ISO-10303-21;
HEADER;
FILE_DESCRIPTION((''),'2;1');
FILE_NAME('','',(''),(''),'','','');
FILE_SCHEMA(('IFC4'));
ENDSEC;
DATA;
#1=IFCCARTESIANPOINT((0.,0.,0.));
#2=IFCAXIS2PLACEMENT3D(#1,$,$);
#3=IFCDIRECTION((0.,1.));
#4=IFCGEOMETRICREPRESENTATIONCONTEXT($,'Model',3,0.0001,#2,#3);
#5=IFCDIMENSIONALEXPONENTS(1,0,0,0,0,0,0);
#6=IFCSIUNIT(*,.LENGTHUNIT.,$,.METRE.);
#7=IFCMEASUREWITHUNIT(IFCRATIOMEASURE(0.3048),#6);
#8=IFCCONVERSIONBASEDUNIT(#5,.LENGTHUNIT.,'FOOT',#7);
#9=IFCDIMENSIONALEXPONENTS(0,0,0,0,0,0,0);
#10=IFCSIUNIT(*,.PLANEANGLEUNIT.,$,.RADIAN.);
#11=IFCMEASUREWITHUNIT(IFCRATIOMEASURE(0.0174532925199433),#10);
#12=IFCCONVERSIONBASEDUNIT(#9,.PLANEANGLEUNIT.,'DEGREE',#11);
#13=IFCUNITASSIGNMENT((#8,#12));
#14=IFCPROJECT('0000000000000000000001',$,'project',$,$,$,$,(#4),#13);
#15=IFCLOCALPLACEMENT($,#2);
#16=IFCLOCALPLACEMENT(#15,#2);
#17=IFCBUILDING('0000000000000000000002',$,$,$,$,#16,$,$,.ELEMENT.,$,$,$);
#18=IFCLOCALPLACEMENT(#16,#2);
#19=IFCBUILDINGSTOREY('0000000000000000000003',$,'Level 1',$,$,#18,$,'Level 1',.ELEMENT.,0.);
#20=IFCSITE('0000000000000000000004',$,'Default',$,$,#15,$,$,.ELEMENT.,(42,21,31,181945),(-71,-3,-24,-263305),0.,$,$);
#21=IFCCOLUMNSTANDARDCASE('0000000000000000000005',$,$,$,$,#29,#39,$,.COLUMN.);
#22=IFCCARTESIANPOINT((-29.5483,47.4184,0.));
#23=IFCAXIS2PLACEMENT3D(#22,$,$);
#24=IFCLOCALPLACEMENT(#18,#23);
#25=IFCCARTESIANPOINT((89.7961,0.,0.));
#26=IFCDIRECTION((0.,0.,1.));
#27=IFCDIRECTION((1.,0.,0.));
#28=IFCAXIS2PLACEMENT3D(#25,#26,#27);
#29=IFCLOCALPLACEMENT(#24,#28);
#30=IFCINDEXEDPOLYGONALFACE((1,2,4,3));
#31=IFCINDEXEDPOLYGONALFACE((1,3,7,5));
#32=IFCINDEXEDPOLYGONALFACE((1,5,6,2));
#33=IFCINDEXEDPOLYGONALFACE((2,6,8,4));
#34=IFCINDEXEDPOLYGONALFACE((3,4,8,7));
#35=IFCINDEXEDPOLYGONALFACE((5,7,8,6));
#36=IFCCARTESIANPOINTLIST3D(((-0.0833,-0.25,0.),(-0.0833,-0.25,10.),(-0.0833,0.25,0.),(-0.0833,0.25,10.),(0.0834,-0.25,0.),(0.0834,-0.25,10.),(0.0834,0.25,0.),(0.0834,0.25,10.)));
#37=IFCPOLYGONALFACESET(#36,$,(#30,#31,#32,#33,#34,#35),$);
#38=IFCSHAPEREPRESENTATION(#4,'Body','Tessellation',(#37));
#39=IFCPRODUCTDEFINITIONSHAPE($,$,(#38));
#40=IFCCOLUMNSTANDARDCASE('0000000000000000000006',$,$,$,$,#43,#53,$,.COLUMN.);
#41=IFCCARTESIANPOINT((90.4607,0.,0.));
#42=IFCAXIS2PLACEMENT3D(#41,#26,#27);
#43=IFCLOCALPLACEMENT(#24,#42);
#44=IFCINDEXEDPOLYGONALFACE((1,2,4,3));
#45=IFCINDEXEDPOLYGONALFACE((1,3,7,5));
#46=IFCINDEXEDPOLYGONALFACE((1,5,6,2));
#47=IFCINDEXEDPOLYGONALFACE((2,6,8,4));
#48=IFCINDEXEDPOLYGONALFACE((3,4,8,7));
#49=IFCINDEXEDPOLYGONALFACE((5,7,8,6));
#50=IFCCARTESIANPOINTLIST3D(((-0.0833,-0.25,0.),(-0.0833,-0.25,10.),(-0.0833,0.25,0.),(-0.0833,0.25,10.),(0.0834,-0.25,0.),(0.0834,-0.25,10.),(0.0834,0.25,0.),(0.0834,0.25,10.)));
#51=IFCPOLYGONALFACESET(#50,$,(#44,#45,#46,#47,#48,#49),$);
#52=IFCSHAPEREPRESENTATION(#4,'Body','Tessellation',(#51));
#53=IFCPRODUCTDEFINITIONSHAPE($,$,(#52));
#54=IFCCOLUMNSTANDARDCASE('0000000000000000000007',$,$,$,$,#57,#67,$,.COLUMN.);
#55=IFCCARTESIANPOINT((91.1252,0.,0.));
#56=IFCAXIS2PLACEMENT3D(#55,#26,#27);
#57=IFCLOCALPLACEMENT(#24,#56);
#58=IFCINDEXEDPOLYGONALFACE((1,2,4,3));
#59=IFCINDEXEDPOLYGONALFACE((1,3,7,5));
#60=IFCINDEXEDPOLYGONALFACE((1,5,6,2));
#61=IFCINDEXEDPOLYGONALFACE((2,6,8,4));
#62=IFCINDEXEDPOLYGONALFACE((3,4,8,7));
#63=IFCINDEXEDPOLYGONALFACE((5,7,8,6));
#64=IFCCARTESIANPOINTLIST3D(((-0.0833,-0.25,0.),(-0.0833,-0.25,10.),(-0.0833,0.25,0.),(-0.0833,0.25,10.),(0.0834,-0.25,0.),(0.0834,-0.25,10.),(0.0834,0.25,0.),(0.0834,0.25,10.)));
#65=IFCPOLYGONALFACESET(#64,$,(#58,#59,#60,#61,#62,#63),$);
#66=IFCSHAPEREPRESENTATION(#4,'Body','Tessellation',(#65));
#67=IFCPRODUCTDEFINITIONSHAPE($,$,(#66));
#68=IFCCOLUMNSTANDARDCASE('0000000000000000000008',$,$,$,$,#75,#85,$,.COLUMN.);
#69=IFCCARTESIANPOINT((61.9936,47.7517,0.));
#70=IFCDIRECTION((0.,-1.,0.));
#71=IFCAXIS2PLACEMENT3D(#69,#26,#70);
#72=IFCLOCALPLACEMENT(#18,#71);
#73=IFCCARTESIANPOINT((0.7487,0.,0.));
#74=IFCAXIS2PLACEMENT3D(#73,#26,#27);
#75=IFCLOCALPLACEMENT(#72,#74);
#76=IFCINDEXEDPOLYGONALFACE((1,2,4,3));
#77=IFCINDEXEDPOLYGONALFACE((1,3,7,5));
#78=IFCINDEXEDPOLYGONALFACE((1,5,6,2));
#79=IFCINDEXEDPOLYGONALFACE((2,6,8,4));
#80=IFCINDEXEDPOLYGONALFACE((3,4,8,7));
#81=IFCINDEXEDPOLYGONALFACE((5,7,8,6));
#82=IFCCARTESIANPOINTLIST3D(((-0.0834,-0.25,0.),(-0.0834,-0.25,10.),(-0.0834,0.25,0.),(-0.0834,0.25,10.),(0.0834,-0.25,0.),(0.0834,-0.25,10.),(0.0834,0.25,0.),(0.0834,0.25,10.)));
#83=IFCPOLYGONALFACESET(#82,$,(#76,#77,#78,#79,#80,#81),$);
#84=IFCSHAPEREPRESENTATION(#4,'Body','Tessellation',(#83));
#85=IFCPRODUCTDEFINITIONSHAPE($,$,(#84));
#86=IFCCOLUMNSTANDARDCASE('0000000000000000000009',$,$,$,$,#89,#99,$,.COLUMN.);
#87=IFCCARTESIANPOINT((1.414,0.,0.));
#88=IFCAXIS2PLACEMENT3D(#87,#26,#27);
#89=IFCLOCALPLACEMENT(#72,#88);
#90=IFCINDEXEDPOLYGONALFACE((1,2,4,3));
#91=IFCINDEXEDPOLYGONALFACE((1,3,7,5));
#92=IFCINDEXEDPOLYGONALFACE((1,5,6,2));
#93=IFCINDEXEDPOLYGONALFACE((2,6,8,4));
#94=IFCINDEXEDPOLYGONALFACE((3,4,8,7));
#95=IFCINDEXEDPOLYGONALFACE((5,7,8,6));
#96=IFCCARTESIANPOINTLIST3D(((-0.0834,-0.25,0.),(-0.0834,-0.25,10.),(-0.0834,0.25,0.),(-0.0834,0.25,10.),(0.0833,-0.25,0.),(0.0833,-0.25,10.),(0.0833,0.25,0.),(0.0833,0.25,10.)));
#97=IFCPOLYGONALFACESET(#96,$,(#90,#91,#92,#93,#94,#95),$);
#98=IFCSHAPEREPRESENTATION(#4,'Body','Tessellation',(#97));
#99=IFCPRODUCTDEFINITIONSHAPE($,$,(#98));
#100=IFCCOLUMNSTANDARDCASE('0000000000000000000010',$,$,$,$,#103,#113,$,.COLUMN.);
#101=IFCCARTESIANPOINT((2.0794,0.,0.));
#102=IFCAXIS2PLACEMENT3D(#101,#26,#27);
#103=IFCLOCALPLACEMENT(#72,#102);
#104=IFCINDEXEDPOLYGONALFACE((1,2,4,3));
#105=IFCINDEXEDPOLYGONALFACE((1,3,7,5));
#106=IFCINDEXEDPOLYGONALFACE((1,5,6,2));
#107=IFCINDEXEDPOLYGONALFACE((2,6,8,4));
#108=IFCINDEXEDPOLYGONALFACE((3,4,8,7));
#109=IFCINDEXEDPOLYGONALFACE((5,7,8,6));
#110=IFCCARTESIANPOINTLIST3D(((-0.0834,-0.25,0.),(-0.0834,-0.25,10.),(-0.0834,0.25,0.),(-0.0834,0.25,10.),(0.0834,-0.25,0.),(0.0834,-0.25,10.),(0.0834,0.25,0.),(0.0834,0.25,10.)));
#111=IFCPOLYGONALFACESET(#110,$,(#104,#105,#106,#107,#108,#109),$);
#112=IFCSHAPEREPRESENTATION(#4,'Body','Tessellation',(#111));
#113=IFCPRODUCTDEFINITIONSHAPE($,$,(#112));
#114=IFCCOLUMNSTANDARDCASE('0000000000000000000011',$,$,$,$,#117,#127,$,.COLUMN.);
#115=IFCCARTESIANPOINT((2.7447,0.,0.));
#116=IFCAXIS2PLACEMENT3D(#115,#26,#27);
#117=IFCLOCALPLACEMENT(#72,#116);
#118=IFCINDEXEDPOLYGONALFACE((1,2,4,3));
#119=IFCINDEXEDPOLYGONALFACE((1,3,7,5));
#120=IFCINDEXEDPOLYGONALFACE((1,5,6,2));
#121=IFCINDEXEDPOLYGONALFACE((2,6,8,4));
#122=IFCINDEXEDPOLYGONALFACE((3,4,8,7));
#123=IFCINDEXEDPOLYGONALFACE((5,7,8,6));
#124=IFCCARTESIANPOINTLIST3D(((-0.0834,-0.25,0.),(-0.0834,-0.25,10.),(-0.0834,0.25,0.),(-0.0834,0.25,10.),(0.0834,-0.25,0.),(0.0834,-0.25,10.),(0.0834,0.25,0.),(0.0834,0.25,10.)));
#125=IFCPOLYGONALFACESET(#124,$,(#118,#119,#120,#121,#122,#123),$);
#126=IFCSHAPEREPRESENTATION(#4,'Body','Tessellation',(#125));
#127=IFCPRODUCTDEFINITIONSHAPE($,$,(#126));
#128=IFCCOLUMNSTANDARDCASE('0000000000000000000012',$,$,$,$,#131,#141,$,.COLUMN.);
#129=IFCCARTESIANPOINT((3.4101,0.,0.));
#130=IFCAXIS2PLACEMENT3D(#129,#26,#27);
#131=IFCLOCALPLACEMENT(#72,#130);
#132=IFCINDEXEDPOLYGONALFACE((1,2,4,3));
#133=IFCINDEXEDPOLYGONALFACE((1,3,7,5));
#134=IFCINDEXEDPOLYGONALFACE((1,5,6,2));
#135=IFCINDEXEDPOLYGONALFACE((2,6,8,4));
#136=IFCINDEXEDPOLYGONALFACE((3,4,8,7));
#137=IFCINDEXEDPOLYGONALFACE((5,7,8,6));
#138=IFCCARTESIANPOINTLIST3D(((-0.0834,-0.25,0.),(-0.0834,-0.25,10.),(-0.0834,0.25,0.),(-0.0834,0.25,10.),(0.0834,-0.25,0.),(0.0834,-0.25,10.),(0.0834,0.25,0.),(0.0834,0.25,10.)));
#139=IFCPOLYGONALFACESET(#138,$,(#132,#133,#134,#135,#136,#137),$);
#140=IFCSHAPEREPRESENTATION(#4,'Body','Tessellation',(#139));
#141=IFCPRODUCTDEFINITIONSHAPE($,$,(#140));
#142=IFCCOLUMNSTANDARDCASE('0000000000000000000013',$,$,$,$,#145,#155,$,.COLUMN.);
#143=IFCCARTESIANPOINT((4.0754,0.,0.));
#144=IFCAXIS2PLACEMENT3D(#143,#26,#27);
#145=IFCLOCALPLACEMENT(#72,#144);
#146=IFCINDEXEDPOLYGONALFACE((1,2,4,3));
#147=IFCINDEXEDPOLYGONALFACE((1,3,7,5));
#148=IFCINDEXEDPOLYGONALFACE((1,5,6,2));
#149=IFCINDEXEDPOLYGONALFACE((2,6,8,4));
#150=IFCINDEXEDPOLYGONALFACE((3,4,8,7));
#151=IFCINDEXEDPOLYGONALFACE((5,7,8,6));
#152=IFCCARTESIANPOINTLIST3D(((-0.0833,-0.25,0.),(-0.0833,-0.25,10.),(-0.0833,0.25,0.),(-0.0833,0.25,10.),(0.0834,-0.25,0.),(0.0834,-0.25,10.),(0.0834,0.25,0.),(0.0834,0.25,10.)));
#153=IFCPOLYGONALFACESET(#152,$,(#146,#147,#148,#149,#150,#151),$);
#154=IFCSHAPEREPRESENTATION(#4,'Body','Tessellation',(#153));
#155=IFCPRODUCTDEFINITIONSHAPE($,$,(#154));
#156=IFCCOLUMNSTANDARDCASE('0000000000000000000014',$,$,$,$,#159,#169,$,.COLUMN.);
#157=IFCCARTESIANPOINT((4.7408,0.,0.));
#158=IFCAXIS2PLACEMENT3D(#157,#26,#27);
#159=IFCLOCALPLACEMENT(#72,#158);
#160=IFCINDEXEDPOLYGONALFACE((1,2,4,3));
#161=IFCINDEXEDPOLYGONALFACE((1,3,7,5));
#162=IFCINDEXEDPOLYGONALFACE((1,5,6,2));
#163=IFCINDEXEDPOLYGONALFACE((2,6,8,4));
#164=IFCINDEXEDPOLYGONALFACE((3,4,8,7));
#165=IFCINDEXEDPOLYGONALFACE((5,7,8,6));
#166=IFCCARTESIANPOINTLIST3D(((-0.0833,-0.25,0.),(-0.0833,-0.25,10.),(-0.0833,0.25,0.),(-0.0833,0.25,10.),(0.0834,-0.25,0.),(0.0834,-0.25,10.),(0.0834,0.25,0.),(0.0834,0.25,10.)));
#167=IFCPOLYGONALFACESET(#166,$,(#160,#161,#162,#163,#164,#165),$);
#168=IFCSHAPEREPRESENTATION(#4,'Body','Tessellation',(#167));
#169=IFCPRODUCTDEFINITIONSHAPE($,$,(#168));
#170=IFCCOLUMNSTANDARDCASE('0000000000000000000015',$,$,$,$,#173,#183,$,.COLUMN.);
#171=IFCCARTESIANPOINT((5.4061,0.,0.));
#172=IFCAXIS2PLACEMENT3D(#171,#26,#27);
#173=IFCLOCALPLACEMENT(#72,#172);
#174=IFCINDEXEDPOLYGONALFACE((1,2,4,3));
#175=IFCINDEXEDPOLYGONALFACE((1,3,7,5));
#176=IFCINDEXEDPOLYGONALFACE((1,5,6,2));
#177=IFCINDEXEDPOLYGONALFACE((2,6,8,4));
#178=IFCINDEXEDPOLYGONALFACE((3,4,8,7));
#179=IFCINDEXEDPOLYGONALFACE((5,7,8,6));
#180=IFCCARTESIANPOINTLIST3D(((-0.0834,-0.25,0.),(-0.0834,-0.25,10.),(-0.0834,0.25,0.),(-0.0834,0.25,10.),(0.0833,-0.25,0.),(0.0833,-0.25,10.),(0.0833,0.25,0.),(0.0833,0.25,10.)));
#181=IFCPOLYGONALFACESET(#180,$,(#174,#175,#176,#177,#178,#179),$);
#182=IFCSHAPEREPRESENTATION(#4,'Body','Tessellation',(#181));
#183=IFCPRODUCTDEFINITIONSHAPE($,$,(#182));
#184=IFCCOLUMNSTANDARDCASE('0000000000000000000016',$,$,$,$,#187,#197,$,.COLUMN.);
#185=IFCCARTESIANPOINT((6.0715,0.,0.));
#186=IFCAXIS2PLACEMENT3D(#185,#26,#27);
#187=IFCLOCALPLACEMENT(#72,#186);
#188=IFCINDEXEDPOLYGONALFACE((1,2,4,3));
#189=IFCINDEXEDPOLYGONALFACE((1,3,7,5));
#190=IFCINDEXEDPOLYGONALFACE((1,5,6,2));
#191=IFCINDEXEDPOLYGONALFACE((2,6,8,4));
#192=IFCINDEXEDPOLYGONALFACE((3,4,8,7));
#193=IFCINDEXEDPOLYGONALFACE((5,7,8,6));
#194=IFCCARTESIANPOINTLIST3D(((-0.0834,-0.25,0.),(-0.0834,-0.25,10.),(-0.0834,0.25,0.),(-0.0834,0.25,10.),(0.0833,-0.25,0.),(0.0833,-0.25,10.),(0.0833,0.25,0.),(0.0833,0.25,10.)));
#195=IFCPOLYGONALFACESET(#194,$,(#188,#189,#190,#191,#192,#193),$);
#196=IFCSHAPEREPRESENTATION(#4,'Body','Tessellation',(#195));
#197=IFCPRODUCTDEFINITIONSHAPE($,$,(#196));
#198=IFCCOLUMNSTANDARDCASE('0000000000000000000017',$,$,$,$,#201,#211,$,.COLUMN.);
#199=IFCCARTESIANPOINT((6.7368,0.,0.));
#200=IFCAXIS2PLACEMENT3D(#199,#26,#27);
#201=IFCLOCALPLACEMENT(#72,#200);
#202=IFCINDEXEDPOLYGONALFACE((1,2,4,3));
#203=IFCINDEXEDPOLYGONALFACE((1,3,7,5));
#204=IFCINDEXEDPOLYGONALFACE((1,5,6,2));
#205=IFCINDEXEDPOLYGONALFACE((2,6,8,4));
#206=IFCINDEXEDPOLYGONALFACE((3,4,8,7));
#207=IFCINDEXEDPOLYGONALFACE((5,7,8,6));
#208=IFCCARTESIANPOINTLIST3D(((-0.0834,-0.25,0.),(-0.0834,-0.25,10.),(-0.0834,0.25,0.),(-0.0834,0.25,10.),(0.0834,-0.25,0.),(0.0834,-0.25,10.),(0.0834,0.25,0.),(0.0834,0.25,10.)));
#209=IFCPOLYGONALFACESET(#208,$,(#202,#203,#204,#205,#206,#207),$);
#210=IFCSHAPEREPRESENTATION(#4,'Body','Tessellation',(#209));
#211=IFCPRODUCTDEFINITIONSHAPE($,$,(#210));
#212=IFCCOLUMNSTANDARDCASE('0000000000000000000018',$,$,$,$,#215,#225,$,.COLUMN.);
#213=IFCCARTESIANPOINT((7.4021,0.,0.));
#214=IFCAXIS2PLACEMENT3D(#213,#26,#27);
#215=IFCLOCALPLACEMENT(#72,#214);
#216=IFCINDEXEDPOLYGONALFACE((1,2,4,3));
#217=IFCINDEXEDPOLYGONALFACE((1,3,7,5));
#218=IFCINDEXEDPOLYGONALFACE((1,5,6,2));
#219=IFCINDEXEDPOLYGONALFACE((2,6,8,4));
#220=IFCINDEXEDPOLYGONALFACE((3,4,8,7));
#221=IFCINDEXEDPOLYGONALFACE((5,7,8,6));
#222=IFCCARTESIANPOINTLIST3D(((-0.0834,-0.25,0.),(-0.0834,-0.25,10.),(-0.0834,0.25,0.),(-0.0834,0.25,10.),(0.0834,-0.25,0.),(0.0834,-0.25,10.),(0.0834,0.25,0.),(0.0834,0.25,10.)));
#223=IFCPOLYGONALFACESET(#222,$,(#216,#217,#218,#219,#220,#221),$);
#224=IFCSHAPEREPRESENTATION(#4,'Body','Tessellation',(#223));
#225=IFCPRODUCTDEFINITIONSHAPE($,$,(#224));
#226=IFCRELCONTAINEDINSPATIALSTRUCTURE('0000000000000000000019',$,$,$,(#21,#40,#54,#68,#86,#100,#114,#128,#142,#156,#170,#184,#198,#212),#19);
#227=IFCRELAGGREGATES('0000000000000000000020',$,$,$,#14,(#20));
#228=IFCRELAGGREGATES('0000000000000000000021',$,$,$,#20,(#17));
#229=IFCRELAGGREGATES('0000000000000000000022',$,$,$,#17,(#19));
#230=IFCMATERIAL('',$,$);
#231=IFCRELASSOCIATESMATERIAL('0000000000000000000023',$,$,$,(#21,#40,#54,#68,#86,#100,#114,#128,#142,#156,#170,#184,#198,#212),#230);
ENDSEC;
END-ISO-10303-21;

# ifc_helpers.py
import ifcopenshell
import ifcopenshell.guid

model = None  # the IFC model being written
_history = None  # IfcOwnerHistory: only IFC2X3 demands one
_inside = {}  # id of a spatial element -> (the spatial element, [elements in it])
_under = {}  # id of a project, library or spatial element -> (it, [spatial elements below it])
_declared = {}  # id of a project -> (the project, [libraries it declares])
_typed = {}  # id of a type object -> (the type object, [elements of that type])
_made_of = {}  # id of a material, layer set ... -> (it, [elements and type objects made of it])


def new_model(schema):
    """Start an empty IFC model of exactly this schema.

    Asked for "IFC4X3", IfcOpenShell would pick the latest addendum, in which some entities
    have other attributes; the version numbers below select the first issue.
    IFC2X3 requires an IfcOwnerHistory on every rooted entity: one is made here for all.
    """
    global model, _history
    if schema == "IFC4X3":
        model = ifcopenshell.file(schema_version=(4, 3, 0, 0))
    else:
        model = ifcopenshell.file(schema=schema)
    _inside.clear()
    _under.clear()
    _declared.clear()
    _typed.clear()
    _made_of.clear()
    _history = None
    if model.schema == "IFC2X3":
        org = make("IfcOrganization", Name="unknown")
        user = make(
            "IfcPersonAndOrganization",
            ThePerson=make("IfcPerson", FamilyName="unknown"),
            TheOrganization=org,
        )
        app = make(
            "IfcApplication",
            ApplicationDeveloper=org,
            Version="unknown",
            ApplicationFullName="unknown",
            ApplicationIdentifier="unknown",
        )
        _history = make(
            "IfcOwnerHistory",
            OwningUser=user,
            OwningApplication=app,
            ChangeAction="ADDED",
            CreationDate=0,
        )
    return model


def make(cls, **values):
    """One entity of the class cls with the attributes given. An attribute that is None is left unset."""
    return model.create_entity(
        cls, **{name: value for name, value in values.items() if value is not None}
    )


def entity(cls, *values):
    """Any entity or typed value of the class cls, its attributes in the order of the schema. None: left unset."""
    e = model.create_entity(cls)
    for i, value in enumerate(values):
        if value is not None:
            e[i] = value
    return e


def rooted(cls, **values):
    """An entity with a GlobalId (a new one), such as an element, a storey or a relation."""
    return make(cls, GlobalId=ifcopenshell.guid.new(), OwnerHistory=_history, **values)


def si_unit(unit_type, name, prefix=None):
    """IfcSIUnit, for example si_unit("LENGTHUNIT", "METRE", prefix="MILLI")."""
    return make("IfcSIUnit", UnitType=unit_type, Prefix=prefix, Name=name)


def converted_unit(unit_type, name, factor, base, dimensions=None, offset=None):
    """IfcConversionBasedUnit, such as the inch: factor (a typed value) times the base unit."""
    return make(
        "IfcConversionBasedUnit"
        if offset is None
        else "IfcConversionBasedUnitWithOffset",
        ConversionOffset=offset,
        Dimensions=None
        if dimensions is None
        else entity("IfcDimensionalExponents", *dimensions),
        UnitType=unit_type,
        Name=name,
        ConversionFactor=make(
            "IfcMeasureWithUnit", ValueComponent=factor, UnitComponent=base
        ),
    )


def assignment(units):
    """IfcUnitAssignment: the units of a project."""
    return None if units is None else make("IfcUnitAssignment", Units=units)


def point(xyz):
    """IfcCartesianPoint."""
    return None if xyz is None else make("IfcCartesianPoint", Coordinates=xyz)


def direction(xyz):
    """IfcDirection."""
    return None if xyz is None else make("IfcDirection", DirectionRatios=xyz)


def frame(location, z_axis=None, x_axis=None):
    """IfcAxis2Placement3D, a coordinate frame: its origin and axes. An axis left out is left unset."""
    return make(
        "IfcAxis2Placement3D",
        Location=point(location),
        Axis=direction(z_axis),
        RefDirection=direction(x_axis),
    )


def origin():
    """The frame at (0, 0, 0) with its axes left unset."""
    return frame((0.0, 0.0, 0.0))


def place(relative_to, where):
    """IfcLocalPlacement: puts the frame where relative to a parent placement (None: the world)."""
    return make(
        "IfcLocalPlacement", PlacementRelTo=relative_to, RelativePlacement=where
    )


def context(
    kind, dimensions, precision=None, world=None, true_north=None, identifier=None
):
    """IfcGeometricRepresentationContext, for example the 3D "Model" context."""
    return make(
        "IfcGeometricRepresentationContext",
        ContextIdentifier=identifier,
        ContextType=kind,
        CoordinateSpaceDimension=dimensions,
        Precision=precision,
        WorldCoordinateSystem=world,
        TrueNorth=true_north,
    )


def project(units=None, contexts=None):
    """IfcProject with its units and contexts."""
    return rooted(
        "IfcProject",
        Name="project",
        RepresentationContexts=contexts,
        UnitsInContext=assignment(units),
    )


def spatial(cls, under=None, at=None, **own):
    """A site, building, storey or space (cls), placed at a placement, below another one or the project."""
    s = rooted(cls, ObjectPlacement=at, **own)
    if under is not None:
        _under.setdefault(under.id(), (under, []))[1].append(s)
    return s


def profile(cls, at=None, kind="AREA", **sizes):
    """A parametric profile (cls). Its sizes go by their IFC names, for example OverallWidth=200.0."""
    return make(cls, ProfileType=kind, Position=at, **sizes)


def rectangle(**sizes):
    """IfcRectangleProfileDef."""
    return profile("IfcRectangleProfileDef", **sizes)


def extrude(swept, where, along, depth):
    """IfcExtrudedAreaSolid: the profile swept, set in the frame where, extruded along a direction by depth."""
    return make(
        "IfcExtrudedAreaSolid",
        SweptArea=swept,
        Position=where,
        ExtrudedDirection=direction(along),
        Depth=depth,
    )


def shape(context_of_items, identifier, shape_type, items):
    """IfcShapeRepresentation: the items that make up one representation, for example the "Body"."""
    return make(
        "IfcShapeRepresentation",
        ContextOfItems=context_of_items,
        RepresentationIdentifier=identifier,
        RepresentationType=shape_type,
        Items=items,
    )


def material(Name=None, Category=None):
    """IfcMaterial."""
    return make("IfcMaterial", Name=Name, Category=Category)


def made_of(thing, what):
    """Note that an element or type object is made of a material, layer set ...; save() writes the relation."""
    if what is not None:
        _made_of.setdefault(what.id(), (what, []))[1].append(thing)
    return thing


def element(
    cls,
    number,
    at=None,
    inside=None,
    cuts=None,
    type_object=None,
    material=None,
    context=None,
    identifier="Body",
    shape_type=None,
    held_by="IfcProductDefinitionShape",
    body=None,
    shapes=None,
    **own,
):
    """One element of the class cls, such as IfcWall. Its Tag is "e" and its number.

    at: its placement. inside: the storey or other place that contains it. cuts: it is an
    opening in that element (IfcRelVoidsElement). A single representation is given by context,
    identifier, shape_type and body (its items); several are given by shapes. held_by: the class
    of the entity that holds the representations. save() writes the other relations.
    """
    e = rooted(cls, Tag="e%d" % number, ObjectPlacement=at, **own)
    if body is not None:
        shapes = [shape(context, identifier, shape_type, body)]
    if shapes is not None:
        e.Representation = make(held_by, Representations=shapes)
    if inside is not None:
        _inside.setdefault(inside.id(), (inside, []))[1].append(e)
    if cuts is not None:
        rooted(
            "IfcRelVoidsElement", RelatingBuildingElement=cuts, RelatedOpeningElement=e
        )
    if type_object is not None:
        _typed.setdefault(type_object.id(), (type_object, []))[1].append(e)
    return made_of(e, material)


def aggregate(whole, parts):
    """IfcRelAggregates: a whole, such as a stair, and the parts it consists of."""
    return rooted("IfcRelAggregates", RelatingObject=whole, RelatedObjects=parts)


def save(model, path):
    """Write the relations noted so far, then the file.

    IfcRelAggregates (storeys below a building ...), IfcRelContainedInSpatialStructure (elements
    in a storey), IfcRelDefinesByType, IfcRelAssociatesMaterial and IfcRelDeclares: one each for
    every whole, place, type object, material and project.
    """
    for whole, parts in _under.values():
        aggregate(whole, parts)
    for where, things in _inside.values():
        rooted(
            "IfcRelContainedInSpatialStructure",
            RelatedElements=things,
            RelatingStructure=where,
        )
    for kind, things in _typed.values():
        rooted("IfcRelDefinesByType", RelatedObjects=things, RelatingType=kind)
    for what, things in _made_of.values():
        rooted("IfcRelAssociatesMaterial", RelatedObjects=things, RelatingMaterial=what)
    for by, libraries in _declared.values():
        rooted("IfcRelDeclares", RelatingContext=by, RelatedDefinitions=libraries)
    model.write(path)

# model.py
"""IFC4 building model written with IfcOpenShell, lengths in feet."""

from ifc_helpers import new_model, entity, si_unit, converted_unit, direction, frame, origin, place, context, project, spatial, rectangle, extrude, material, element, save


model = new_model("IFC4")

# Units and contexts
model_context = context("Model", 3, precision=0.0001, world=origin(), true_north=direction((0.0, 1.0)))
ifc_project = project(units=[converted_unit("LENGTHUNIT", "FOOT", entity("IfcRatioMeasure", 0.3048), si_unit("LENGTHUNIT", "METRE"), dimensions=[1, 0, 0, 0, 0, 0, 0]), converted_unit("PLANEANGLEUNIT", "DEGREE", entity("IfcRatioMeasure", 0.0174532925199433), si_unit("PLANEANGLEUNIT", "RADIAN"), dimensions=[0, 0, 0, 0, 0, 0, 0])], contexts=[model_context])

# Site, building, storey
site_placement = place(None, origin())
site = spatial("IfcSite", under=ifc_project, at=site_placement, Name="Default", CompositionType="ELEMENT", RefLatitude=(42, 21, 31, 181945), RefLongitude=(-71, -3, -24, -263305), RefElevation=0.0)
building_placement = place(site_placement, origin())
building = spatial("IfcBuilding", under=site, at=building_placement, CompositionType="ELEMENT")
storey_placement = place(building_placement, origin())
storey = spatial("IfcBuildingStorey", under=building, at=storey_placement, Name="Level 1", LongName="Level 1", CompositionType="ELEMENT", Elevation=0.0)

# Columns
ifc_material_1 = material(Name="")
placement = place(storey_placement, frame((-29.5483, 47.4184, 0.0)))
for number, where, z_axis, x_axis in (
    (1, (89.7961, 0.0, 0.0), (0.0, 0.0, 1.0), (1.0, 0.0, 0.0)),
    (2, (90.4607, 0.0, 0.0), (0.0, 0.0, 1.0), (1.0, 0.0, 0.0)),
    (3, (91.1252, 0.0, 0.0), (0.0, 0.0, 1.0), (1.0, 0.0, 0.0)),
):
    element("IfcColumnStandardCase", number, at=place(placement, frame(where, z_axis=z_axis, x_axis=x_axis)), inside=storey, material=ifc_material_1, PredefinedType="COLUMN", context=model_context, shape_type="SweptSolid", body=[
        extrude(rectangle(XDim=0.1667, YDim=0.5), origin(), (0.0, 0.0, 1.0), 10.0),
    ])
wall_placement = place(storey_placement, frame((61.9936, 47.7517, 0.0), z_axis=(0.0, 0.0, 1.0), x_axis=(0.0, -1.0, 0.0)))
for number, where, z_axis, x_axis in (
    (4, (0.7487, 0.0, 0.0), (0.0, 0.0, 1.0), (1.0, 0.0, 0.0)),
    (5, (1.414, 0.0, 0.0), (0.0, 0.0, 1.0), (1.0, 0.0, 0.0)),
    (6, (2.0794, 0.0, 0.0), (0.0, 0.0, 1.0), (1.0, 0.0, 0.0)),
    (7, (2.7447, 0.0, 0.0), (0.0, 0.0, 1.0), (1.0, 0.0, 0.0)),
    (8, (3.4101, 0.0, 0.0), (0.0, 0.0, 1.0), (1.0, 0.0, 0.0)),
    (9, (4.0754, 0.0, 0.0), (0.0, 0.0, 1.0), (1.0, 0.0, 0.0)),
    (10, (4.7408, 0.0, 0.0), (0.0, 0.0, 1.0), (1.0, 0.0, 0.0)),
    (11, (5.4061, 0.0, 0.0), (0.0, 0.0, 1.0), (1.0, 0.0, 0.0)),
    (12, (6.0715, 0.0, 0.0), (0.0, 0.0, 1.0), (1.0, 0.0, 0.0)),
    (13, (6.7368, 0.0, 0.0), (0.0, 0.0, 1.0), (1.0, 0.0, 0.0)),
    (14, (7.4021, 0.0, 0.0), (0.0, 0.0, 1.0), (1.0, 0.0, 0.0)),
):
    element("IfcColumnStandardCase", number, at=place(wall_placement, frame(where, z_axis=z_axis, x_axis=x_axis)), inside=storey, material=ifc_material_1, PredefinedType="COLUMN", context=model_context, shape_type="SweptSolid", body=[
        extrude(rectangle(XDim=0.1667, YDim=0.5), origin(), (0.0, 0.0, 1.0), 10.0),
    ])

save(model, "model.ifc")
